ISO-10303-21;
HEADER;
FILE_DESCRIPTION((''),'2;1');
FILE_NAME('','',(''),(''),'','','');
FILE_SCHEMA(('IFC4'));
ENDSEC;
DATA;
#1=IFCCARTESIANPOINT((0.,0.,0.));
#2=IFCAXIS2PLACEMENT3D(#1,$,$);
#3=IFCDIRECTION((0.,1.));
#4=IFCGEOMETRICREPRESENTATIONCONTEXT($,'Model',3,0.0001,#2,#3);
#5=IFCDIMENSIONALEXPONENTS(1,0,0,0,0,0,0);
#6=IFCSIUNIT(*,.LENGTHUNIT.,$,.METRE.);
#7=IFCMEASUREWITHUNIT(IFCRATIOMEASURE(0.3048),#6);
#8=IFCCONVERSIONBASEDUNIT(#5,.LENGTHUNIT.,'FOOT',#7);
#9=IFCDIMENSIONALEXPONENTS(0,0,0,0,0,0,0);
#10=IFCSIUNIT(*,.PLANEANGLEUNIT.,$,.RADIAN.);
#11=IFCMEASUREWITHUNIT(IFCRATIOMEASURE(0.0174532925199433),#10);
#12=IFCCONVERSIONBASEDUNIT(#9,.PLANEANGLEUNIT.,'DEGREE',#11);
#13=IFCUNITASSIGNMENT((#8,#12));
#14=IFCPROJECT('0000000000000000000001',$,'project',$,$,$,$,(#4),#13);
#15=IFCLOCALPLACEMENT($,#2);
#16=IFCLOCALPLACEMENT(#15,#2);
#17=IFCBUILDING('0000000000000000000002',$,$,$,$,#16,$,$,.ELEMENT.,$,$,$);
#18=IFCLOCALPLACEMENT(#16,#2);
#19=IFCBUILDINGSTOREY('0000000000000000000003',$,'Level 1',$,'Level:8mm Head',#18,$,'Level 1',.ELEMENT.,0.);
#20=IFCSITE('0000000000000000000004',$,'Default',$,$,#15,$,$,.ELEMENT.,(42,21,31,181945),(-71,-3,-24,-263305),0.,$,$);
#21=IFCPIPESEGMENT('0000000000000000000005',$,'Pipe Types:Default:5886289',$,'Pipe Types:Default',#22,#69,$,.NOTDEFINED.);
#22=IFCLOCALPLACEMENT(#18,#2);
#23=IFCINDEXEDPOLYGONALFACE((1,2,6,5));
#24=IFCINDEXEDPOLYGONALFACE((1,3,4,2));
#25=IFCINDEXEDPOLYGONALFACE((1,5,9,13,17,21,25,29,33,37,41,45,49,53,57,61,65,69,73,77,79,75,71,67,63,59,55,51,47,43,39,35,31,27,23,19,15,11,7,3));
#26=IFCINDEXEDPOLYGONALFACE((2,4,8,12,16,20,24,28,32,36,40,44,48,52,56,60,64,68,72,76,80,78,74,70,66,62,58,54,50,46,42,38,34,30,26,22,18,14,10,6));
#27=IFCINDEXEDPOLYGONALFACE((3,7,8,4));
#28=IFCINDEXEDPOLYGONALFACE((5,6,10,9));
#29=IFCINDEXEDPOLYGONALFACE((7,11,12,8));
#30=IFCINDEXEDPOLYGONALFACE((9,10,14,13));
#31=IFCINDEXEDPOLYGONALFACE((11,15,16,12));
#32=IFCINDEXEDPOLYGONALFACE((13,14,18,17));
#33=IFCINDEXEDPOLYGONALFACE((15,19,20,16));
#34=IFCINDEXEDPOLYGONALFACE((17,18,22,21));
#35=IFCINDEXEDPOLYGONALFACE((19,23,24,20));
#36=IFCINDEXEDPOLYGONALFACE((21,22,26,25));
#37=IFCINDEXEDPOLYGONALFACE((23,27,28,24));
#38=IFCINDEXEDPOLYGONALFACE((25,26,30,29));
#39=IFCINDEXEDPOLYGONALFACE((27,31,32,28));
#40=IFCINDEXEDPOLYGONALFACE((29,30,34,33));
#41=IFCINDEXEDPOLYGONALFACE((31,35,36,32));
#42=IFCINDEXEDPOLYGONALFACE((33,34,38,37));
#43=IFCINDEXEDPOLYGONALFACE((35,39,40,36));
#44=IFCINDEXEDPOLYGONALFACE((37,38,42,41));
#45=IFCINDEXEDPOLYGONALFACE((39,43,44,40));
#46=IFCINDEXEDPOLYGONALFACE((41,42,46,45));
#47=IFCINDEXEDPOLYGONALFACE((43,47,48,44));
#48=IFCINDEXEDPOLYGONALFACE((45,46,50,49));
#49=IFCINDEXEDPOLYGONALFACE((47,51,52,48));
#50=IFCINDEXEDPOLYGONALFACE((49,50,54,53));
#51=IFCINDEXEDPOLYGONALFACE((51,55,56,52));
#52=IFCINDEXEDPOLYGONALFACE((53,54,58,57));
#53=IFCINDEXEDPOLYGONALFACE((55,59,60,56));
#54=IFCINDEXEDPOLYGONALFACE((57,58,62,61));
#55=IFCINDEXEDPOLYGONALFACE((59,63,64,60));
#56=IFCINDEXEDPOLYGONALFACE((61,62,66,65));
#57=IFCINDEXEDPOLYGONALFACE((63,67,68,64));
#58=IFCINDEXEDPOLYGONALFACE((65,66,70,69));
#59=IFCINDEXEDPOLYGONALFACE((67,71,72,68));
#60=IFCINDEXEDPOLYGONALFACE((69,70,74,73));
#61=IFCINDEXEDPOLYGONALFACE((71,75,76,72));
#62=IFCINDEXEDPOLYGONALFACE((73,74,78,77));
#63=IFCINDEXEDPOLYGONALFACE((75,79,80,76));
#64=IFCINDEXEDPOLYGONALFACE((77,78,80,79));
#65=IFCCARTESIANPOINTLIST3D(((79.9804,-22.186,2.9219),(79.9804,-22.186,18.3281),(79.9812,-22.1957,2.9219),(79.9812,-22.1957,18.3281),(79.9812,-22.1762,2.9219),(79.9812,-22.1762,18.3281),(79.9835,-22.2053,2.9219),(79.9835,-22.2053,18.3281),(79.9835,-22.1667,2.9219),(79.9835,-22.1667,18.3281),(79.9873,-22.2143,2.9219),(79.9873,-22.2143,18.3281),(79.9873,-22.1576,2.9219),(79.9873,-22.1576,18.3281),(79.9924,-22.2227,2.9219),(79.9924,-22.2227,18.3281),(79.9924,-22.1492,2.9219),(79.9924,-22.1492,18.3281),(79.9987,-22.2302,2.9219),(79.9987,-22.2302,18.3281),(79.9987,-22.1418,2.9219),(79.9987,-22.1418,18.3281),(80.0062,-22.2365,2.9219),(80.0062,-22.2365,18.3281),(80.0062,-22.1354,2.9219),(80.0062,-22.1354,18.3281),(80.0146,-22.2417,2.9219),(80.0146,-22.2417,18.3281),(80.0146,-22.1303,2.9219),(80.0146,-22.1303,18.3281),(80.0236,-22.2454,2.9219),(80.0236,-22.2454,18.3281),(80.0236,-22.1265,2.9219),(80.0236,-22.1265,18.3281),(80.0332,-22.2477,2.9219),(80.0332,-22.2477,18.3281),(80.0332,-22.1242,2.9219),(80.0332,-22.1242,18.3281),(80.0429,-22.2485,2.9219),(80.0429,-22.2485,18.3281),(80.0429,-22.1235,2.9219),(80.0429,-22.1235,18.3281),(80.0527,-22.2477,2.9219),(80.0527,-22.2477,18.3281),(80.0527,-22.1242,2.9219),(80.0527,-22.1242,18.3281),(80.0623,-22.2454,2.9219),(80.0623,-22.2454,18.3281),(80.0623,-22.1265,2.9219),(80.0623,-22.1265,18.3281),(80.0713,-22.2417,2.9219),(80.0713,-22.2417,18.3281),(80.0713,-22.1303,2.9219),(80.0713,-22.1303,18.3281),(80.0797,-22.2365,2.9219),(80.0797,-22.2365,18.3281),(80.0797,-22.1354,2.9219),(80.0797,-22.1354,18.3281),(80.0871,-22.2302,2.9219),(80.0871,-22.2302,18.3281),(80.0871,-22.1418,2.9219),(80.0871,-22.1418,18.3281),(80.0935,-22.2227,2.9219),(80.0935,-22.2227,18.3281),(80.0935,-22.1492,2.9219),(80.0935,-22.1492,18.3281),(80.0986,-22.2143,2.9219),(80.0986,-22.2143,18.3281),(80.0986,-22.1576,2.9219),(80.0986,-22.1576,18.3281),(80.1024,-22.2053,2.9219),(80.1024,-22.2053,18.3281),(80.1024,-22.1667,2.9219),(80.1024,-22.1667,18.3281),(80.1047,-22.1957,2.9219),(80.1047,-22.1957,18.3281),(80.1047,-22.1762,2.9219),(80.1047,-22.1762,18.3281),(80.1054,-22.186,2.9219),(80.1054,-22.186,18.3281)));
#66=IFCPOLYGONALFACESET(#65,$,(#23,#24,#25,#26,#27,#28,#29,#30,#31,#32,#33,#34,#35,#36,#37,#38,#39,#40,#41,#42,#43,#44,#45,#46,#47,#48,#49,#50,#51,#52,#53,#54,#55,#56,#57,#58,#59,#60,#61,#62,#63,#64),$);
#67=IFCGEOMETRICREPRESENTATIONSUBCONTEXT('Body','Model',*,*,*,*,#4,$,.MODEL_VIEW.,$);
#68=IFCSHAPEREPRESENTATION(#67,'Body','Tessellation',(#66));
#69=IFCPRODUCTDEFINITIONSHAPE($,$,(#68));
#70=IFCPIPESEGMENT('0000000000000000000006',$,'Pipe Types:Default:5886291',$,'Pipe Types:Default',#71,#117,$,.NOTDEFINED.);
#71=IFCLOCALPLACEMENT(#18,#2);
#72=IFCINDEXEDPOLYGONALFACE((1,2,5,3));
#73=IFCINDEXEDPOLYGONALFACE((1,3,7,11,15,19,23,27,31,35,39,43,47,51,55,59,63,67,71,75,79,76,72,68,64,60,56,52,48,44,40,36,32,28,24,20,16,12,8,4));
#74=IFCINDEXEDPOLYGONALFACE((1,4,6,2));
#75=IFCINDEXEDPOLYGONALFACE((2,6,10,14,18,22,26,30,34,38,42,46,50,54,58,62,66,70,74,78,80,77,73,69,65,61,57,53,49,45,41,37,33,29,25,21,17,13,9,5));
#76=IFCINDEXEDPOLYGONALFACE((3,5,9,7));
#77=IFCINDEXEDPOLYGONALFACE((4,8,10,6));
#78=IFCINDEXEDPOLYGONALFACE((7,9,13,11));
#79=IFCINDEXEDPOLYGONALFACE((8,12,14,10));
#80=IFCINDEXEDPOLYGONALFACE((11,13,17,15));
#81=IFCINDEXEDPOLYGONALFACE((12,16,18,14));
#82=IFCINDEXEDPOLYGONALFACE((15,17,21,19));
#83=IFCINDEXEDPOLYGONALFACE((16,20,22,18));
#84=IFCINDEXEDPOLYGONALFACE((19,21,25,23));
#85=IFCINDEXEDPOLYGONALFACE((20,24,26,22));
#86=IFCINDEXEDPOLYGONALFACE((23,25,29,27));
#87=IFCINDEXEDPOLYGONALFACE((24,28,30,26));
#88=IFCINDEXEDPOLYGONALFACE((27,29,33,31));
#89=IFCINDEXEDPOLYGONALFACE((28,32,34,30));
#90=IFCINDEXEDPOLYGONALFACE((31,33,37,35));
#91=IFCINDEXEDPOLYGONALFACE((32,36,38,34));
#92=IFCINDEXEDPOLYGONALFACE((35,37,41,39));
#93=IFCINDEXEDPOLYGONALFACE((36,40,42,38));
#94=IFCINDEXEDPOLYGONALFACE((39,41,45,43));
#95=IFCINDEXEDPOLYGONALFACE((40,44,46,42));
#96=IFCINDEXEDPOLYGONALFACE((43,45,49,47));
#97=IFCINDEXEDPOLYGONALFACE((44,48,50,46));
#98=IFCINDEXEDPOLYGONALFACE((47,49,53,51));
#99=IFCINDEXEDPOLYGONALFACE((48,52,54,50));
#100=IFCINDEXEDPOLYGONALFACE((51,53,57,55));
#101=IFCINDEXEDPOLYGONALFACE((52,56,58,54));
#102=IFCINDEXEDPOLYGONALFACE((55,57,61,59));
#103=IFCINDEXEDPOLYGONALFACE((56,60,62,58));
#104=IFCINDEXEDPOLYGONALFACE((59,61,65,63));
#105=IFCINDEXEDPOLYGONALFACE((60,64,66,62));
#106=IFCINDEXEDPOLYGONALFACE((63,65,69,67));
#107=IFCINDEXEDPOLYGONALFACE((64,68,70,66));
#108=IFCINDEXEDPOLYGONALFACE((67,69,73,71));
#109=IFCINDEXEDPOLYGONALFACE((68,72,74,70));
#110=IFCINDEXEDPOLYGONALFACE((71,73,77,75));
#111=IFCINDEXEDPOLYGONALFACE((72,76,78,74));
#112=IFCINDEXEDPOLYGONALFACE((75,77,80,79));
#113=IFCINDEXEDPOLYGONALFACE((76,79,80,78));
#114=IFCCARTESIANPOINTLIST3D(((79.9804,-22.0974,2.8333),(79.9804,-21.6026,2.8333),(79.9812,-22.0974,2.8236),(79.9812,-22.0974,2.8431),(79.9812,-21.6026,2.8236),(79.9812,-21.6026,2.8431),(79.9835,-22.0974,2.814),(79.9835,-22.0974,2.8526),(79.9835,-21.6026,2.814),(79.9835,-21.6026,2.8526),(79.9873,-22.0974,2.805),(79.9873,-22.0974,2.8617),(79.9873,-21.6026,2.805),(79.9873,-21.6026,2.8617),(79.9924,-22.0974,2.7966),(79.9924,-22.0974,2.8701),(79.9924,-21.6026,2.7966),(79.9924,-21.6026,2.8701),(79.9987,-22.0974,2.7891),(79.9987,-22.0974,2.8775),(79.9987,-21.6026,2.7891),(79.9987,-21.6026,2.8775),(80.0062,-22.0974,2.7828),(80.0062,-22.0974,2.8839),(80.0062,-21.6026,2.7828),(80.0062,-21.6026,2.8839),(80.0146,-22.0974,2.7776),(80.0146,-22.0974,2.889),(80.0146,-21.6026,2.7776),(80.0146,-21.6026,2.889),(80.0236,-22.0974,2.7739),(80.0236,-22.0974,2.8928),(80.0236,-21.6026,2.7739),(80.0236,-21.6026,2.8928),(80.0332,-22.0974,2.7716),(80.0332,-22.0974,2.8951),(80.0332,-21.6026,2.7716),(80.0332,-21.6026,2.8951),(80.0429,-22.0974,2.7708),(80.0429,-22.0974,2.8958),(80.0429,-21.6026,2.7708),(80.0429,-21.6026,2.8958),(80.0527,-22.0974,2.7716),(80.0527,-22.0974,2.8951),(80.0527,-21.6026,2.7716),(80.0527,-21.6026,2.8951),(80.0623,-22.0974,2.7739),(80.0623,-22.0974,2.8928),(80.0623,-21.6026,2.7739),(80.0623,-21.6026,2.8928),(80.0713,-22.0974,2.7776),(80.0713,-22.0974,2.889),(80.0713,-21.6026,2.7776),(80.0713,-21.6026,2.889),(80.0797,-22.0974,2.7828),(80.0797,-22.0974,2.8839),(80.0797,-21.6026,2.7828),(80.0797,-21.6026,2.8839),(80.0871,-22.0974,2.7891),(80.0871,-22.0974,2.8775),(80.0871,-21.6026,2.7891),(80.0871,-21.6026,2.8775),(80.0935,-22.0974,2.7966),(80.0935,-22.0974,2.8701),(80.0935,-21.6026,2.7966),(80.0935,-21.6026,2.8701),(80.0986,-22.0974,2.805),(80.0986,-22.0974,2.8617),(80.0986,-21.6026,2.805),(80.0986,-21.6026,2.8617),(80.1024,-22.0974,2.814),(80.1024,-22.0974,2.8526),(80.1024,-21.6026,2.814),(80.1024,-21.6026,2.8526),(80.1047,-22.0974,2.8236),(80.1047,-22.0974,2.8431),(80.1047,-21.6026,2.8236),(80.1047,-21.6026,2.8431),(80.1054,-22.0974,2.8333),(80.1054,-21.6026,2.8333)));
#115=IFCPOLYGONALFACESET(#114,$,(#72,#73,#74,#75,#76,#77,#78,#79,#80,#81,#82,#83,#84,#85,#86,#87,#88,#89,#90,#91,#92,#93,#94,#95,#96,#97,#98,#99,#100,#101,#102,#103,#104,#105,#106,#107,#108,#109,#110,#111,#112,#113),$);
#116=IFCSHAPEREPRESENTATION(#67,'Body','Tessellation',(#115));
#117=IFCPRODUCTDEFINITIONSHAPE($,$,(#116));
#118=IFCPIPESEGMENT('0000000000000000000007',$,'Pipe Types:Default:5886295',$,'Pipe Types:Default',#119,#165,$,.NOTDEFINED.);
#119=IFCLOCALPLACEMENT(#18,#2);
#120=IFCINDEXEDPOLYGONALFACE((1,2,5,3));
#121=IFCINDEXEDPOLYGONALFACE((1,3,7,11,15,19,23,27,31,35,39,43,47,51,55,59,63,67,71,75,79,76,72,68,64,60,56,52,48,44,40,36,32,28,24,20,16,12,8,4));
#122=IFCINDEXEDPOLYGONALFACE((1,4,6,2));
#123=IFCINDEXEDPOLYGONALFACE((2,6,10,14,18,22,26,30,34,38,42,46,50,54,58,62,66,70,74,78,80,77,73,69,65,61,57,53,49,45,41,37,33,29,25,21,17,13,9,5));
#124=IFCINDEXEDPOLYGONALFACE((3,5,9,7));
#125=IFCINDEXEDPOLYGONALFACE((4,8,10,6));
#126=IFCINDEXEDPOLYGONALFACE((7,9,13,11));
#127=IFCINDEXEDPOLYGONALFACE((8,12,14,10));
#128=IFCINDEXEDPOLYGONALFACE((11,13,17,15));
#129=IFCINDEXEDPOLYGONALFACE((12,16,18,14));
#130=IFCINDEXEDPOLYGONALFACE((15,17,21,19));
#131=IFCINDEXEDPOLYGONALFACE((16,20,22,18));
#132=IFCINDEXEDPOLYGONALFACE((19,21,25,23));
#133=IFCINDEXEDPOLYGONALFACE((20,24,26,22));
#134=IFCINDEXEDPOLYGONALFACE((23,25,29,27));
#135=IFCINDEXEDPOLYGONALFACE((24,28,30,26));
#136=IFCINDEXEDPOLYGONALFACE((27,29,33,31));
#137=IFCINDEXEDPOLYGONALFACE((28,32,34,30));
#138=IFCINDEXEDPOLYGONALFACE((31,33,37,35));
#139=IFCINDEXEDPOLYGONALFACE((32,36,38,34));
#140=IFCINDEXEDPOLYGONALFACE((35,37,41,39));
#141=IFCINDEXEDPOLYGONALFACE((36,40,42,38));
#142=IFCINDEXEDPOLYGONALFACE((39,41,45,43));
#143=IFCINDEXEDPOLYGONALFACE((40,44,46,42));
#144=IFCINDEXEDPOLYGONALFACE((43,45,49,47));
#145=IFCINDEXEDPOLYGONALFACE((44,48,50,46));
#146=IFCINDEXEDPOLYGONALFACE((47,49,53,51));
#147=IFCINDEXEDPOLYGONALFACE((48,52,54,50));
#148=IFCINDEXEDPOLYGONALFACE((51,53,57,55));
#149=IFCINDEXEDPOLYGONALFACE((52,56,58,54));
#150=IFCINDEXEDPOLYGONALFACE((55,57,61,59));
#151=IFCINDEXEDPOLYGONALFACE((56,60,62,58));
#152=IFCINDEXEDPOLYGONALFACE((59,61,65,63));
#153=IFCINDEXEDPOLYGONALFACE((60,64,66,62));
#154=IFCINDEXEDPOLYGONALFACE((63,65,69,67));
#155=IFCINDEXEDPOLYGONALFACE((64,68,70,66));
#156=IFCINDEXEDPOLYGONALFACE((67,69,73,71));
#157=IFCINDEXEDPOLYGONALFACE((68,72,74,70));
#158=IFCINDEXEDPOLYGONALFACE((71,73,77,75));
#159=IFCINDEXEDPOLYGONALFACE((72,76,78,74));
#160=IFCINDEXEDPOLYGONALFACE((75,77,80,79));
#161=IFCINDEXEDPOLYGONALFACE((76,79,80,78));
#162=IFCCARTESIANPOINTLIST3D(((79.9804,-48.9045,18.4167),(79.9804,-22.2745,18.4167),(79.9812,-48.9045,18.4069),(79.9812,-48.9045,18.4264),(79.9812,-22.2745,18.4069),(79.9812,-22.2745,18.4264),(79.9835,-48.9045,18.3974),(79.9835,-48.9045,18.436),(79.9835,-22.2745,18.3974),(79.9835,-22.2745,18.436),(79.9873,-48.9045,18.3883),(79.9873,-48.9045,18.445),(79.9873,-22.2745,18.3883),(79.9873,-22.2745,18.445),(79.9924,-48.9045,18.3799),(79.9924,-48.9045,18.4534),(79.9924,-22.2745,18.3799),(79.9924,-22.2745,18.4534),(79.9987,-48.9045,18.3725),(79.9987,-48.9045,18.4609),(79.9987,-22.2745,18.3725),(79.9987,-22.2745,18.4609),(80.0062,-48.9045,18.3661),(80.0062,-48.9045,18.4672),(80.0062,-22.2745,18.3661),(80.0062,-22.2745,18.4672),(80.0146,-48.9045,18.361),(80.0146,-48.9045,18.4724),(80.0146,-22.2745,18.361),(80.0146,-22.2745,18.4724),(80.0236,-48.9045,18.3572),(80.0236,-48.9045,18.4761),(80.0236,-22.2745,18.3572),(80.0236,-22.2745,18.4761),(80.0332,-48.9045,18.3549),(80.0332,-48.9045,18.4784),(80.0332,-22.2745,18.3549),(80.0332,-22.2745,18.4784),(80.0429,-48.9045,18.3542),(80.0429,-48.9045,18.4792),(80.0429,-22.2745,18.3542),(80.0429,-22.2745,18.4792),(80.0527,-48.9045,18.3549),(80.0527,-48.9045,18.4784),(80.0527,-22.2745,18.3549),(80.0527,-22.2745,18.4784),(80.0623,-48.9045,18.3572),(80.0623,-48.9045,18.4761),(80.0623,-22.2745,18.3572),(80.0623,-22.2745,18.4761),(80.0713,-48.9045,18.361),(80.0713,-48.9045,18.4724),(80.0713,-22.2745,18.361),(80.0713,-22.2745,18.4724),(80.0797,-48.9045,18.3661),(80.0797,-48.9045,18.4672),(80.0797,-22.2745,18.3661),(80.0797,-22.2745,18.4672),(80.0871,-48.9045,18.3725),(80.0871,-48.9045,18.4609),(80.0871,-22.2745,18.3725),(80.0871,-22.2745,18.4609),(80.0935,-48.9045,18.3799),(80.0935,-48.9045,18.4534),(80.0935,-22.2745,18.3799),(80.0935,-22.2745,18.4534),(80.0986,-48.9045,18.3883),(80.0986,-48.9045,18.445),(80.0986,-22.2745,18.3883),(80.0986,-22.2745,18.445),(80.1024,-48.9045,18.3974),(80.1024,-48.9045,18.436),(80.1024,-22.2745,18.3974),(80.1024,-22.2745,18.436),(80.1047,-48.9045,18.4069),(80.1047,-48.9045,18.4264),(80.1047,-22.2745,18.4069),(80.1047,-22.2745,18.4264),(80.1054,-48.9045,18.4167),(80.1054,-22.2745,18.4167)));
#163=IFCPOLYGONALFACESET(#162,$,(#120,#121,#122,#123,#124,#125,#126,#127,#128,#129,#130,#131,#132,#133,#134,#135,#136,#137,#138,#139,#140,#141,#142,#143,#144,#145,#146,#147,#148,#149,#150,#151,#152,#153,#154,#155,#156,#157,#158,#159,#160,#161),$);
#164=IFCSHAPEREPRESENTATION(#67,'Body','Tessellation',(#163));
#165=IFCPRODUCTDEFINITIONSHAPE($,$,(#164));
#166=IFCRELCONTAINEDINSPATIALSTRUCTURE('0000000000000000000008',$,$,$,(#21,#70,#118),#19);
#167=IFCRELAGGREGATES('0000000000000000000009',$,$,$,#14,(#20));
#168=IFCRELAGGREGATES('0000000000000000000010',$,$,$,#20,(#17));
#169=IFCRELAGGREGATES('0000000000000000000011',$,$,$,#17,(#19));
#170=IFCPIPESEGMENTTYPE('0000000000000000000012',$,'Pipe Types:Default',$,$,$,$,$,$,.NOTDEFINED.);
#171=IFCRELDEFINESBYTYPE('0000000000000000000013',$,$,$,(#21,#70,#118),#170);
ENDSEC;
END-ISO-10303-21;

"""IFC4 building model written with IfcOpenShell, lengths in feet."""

from ifc_helpers import new_model, entity, si_unit, converted_unit, direction, frame, origin, place, context, subcontext, project, spatial, indexed_curve, outline, extrude, type_object, element, save


model = new_model("IFC4")

# Units and contexts
model_context = context("Model", 3, precision=0.0001, world=origin(), true_north=direction((0.0, 1.0)))
body_context = subcontext(model_context, "Body", "Model", "MODEL_VIEW")
ifc_project = project(units=[converted_unit("LENGTHUNIT", "FOOT", entity("IfcRatioMeasure", 0.3048), si_unit("LENGTHUNIT", "METRE"), dimensions=[1, 0, 0, 0, 0, 0, 0]), converted_unit("PLANEANGLEUNIT", "DEGREE", entity("IfcRatioMeasure", 0.0174532925199433), si_unit("PLANEANGLEUNIT", "RADIAN"), dimensions=[0, 0, 0, 0, 0, 0, 0])], contexts=[model_context])

# Site, building, storey
site_placement = place(None, origin())
site = spatial("IfcSite", under=ifc_project, at=site_placement, Name="Default", CompositionType="ELEMENT", RefLatitude=(42, 21, 31, 181945), RefLongitude=(-71, -3, -24, -263305), RefElevation=0.0)
building_placement = place(site_placement, origin())
building = spatial("IfcBuilding", under=site, at=building_placement, CompositionType="ELEMENT")
storey_placement = place(building_placement, origin())
storey = spatial("IfcBuildingStorey", under=building, at=storey_placement, Name="Level 1", ObjectType="Level:8mm Head", LongName="Level 1", CompositionType="ELEMENT", Elevation=0.0)

# Pipe segments
pipe_segment_type = type_object("IfcPipeSegmentType", Name="Pipe Types:Default", PredefinedType="NOTDEFINED")
pipe_segment_1_placement = place(storey_placement, origin())
element("IfcPipeSegment", 1, at=pipe_segment_1_placement, inside=storey, type_object=pipe_segment_type, Name="Pipe Types:Default:5886289", ObjectType="Pipe Types:Default", PredefinedType="NOTDEFINED", context=body_context, shape_type="SweptSolid", body=[
    extrude(outline(indexed_curve([(0.0625, 0.0), (0.0617, 0.0098), (0.0594, 0.0193), (0.0557, 0.0284), (0.0506, 0.0367), (0.0442, 0.0442), (0.0367, 0.0506), (0.0284, 0.0557), (0.0193, 0.0594), (0.0098, 0.0617), (0.0, 0.0625), (-0.0098, 0.0617), (-0.0193, 0.0594), (-0.0284, 0.0557), (-0.0367, 0.0506), (-0.0442, 0.0442), (-0.0506, 0.0367), (-0.0557, 0.0284), (-0.0594, 0.0193), (-0.0617, 0.0098), (-0.0625, 0.0), (-0.0617, -0.0098), (-0.0594, -0.0193), (-0.0557, -0.0284), (-0.0506, -0.0367), (-0.0442, -0.0442), (-0.0367, -0.0506), (-0.0284, -0.0557), (-0.0193, -0.0594), (-0.0098, -0.0617), (0.0, -0.0625), (0.0098, -0.0617), (0.0193, -0.0594), (0.0284, -0.0557), (0.0367, -0.0506), (0.0442, -0.0442), (0.0506, -0.0367), (0.0557, -0.0284), (0.0594, -0.0193), (0.0617, -0.0098), (0.0625, 0.0)], self_intersect=False)), frame((80.0429, -22.186, 2.9219), z_axis=(0.0, 0.0, 1.0), x_axis=(-1.0, 0.0, 0.0)), (0.0, 0.0, 1.0), 15.4062),
])
pipe_segment_2_placement = place(storey_placement, origin())
element("IfcPipeSegment", 2, at=pipe_segment_2_placement, inside=storey, type_object=pipe_segment_type, Name="Pipe Types:Default:5886291", ObjectType="Pipe Types:Default", PredefinedType="NOTDEFINED", context=body_context, shape_type="SweptSolid", body=[
    extrude(outline(indexed_curve([(0.0625, 0.0), (0.0617, 0.0098), (0.0594, 0.0193), (0.0557, 0.0284), (0.0506, 0.0367), (0.0442, 0.0442), (0.0367, 0.0506), (0.0284, 0.0557), (0.0193, 0.0594), (0.0098, 0.0617), (0.0, 0.0625), (-0.0098, 0.0617), (-0.0193, 0.0594), (-0.0284, 0.0557), (-0.0367, 0.0506), (-0.0442, 0.0442), (-0.0506, 0.0367), (-0.0557, 0.0284), (-0.0594, 0.0193), (-0.0617, 0.0098), (-0.0625, 0.0), (-0.0617, -0.0098), (-0.0594, -0.0193), (-0.0557, -0.0284), (-0.0506, -0.0367), (-0.0442, -0.0442), (-0.0367, -0.0506), (-0.0284, -0.0557), (-0.0193, -0.0594), (-0.0098, -0.0617), (0.0, -0.0625), (0.0098, -0.0617), (0.0193, -0.0594), (0.0284, -0.0557), (0.0367, -0.0506), (0.0442, -0.0442), (0.0506, -0.0367), (0.0557, -0.0284), (0.0594, -0.0193), (0.0617, -0.0098), (0.0625, 0.0)], self_intersect=False)), frame((80.0429, -22.0974, 2.8333), z_axis=(0.0, 1.0, 0.0), x_axis=(1.0, 0.0, 0.0)), (0.0, 0.0, 1.0), 0.4948),
])
pipe_segment_3_placement = place(storey_placement, origin())
element("IfcPipeSegment", 3, at=pipe_segment_3_placement, inside=storey, type_object=pipe_segment_type, Name="Pipe Types:Default:5886295", ObjectType="Pipe Types:Default", PredefinedType="NOTDEFINED", context=body_context, shape_type="SweptSolid", body=[
    extrude(outline(indexed_curve([(0.0625, 0.0), (0.0617, 0.0098), (0.0594, 0.0193), (0.0557, 0.0284), (0.0506, 0.0367), (0.0442, 0.0442), (0.0367, 0.0506), (0.0284, 0.0557), (0.0193, 0.0594), (0.0098, 0.0617), (0.0, 0.0625), (-0.0098, 0.0617), (-0.0193, 0.0594), (-0.0284, 0.0557), (-0.0367, 0.0506), (-0.0442, 0.0442), (-0.0506, 0.0367), (-0.0557, 0.0284), (-0.0594, 0.0193), (-0.0617, 0.0098), (-0.0625, 0.0), (-0.0617, -0.0098), (-0.0594, -0.0193), (-0.0557, -0.0284), (-0.0506, -0.0367), (-0.0442, -0.0442), (-0.0367, -0.0506), (-0.0284, -0.0557), (-0.0193, -0.0594), (-0.0098, -0.0617), (0.0, -0.0625), (0.0098, -0.0617), (0.0193, -0.0594), (0.0284, -0.0557), (0.0367, -0.0506), (0.0442, -0.0442), (0.0506, -0.0367), (0.0557, -0.0284), (0.0594, -0.0193), (0.0617, -0.0098), (0.0625, 0.0)], self_intersect=False)), frame((80.0429, -48.9045, 18.4167), z_axis=(0.0, 1.0, 0.0), x_axis=(-1.0, 0.0, 0.0)), (0.0, 0.0, 1.0), 26.63),
])

save(model, "model.ifc")
